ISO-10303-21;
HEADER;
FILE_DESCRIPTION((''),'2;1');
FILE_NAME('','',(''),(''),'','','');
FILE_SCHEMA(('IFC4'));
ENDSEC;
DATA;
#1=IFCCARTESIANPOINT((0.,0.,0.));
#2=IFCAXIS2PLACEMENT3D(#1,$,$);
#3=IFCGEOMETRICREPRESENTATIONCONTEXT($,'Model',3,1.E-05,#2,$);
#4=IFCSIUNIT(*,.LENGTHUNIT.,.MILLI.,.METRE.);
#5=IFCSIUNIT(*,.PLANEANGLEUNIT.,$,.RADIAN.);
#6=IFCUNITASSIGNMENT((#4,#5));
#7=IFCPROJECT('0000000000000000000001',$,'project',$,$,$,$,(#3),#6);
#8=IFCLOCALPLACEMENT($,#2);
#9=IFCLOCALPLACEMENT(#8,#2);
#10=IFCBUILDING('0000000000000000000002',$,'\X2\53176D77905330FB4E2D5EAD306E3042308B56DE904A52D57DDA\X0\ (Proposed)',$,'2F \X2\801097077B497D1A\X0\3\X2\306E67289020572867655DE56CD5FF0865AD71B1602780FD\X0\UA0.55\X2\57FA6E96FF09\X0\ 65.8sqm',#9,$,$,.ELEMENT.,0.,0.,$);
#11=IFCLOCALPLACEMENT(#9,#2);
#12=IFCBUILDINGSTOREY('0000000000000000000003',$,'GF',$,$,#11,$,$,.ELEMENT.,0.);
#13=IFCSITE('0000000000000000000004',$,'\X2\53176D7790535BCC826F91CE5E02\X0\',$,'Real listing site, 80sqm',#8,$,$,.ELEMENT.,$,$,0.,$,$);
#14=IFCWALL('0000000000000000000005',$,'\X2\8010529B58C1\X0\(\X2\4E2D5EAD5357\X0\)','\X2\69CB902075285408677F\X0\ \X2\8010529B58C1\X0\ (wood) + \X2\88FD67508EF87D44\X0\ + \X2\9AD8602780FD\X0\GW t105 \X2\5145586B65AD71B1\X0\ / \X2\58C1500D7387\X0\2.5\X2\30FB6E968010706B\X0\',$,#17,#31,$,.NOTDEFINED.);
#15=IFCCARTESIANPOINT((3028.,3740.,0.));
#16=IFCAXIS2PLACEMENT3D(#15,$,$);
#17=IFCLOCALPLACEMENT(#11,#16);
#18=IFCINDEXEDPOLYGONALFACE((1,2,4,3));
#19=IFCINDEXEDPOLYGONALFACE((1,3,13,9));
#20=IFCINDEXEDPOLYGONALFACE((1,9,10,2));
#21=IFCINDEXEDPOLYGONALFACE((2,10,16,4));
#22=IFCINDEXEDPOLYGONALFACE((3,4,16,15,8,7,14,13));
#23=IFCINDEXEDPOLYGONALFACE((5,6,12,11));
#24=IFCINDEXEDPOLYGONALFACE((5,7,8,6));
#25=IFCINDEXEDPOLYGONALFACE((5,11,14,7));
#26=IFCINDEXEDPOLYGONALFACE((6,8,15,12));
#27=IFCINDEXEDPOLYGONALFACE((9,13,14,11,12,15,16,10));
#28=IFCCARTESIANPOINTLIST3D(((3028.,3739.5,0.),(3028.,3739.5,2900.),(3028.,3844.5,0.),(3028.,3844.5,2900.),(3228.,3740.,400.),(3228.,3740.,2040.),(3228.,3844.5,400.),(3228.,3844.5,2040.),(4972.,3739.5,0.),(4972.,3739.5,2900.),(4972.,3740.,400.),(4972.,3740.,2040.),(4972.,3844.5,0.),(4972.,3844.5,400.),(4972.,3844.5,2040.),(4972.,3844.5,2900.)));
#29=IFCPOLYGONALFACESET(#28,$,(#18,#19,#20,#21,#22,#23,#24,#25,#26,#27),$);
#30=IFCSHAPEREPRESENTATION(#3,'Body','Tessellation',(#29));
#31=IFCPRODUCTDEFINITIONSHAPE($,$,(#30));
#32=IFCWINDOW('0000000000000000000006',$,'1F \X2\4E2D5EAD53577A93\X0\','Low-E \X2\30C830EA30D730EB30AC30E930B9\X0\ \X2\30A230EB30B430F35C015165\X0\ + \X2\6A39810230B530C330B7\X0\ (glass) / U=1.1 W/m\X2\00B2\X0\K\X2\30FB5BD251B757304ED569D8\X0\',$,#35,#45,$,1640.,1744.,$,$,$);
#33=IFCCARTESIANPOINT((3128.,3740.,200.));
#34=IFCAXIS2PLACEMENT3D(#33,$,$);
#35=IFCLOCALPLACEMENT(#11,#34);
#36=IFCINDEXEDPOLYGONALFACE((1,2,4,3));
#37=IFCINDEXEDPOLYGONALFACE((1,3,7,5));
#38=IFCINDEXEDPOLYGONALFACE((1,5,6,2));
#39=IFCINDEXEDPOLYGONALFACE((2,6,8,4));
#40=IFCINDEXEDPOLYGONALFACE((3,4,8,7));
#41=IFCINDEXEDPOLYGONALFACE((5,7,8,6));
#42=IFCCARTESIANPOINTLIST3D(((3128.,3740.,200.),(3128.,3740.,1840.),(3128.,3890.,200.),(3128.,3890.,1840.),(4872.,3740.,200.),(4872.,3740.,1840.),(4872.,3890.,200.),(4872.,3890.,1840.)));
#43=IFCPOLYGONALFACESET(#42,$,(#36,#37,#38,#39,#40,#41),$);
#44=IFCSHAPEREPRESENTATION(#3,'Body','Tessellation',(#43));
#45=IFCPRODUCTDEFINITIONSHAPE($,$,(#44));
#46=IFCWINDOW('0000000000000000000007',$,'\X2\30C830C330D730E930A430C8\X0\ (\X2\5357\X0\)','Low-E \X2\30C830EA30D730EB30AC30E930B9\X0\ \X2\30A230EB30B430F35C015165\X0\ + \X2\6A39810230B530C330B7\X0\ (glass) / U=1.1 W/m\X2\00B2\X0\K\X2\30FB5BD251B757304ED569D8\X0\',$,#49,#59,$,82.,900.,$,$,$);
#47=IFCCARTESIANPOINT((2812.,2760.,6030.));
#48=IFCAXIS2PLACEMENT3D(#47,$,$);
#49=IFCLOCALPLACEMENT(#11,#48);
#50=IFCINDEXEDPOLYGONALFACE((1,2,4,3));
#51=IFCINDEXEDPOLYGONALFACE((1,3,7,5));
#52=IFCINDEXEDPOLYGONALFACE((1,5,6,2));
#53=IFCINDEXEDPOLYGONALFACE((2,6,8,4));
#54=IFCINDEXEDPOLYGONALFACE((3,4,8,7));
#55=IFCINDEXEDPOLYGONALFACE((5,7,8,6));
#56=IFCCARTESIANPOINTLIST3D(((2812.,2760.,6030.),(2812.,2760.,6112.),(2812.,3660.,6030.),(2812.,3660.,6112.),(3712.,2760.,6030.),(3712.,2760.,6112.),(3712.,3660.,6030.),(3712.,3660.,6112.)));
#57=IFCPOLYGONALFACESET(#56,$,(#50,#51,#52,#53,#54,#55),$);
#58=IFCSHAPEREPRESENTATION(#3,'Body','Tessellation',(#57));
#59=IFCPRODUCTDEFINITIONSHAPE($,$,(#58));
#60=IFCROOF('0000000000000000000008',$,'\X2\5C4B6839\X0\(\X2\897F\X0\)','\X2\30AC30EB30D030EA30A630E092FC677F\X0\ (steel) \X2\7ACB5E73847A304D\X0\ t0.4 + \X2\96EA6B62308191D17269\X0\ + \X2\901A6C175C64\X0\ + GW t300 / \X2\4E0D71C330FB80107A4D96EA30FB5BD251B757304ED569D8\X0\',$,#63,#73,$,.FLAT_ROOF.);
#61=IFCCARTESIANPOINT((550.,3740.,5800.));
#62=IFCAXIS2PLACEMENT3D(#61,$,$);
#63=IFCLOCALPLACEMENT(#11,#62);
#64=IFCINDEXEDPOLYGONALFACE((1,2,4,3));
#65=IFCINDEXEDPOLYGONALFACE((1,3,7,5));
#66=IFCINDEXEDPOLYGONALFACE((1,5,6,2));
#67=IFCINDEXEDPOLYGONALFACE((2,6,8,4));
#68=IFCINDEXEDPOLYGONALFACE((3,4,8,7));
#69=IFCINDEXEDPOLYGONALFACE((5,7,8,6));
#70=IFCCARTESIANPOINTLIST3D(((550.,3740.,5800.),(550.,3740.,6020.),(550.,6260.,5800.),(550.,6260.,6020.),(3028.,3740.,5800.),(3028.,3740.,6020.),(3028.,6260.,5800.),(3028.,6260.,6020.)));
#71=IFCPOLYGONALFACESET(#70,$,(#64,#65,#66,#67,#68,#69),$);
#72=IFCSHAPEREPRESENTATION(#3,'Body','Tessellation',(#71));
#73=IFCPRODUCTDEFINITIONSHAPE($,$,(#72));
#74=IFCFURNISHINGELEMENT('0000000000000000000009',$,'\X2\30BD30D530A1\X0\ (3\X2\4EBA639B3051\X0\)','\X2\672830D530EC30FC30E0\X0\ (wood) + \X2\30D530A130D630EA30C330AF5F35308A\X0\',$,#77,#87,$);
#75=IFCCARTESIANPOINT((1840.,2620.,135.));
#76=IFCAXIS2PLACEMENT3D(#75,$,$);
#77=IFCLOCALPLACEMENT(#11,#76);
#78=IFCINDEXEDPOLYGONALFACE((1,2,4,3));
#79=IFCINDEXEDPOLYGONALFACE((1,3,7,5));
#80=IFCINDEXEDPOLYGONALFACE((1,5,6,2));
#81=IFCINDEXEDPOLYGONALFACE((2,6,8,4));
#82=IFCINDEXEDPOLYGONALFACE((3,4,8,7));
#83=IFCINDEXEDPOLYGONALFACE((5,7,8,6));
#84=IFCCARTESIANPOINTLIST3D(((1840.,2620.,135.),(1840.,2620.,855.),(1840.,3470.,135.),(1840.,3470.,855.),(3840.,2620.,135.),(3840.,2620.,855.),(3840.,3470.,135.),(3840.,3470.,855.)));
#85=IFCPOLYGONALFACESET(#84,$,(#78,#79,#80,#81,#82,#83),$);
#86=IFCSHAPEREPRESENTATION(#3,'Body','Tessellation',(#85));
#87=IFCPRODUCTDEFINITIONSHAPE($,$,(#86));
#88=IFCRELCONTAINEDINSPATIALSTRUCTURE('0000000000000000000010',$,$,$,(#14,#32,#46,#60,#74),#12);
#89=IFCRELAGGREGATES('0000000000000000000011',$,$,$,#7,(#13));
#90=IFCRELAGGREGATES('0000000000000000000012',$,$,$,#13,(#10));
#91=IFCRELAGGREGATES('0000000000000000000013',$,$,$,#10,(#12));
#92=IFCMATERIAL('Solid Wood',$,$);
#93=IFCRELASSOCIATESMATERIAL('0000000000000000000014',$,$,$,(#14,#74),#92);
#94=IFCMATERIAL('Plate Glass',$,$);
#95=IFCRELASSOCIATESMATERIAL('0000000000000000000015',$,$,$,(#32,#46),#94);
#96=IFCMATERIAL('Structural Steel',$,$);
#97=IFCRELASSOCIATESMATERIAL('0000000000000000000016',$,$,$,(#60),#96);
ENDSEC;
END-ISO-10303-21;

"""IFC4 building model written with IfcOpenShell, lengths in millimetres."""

from ifc_helpers import new_model, si_unit, frame, frame_2d, origin, place, context, project, spatial, rectangle, extrude, material, element, fill, save


model = new_model("IFC4")

# Units and contexts
model_context = context("Model", 3, precision=1e-05, world=origin())
ifc_project = project(units=[si_unit("LENGTHUNIT", "METRE", prefix="MILLI"), si_unit("PLANEANGLEUNIT", "RADIAN")], contexts=[model_context])

# Site, building, storey
site_placement = place(None, origin())
site = spatial("IfcSite", under=ifc_project, at=site_placement, Name="北海道富良野市", ObjectType="Real listing site, 80sqm", CompositionType="ELEMENT", RefElevation=0.0)
building_placement = place(site_placement, origin())
building = spatial("IfcBuilding", under=site, at=building_placement, Name="北海道・中庭のある回遊動線 (Proposed)", ObjectType="2F 耐震等級3の木造在来工法（断熱性能UA0.55基準） 65.8sqm", CompositionType="ELEMENT", ElevationOfRefHeight=0.0, ElevationOfTerrain=0.0)
storey_placement = place(building_placement, origin())
storey = spatial("IfcBuildingStorey", under=building, at=storey_placement, Name="GF", CompositionType="ELEMENT", Elevation=0.0)

# Shared definitions
ifc_material_1 = material(Name="Solid Wood")

# Wall, opening, window
wall_placement = place(storey_placement, frame((3028.0, 3740.0, 0.0)))
wall = element("IfcWall", 1, at=wall_placement, inside=storey, material=ifc_material_1, Name="耐力壁(中庭南)", Description="構造用合板 耐力壁 (wood) + 製材軸組 + 高性能GW t105 充填断熱 / 壁倍率2.5・準耐火", PredefinedType="NOTDEFINED", context=model_context, shape_type="SweptSolid", body=[
    extrude(rectangle(XDim=1944.0, YDim=105.0, at=frame_2d((972.0, 52.0))), frame((3028.0, 3740.0, 0.0)), (0.0, 0.0, 1.0), 2900.0),
])
opening_placement = place(storey_placement, frame((3128.0, 3740.0, 200.0)))
opening = element("IfcOpeningElement", 2, at=opening_placement, cuts=wall, PredefinedType="NOTDEFINED", context=model_context, shape_type="SweptSolid", body=[
    extrude(rectangle(XDim=1744.0, YDim=150.0, at=frame_2d((872.0, 75.0))), frame((3128.0, 3740.0, 200.0)), (0.0, 0.0, 1.0), 1640.0),
])
ifc_material_2 = material(Name="Plate Glass")
window_1_placement = place(storey_placement, frame((3128.0, 3740.0, 200.0)))
window_1 = element("IfcWindow", 3, at=window_1_placement, inside=storey, material=ifc_material_2, Name="1F 中庭南窓", Description="Low-E トリプルガラス アルゴン封入 + 樹脂サッシ (glass) / U=1.1 W/m²K・寒冷地仕様", OverallHeight=1640.0, OverallWidth=1744.0, context=model_context, shape_type="SweptSolid", body=[
    extrude(rectangle(XDim=1744.0, YDim=150.0, at=frame_2d((872.0, 75.0))), frame((3128.0, 3740.0, 200.0)), (0.0, 0.0, 1.0), 1640.0),
])
fill(opening, window_1)

# Window
window_2_placement = place(storey_placement, frame((2812.0, 2760.0, 6030.0)))
element("IfcWindow", 4, at=window_2_placement, inside=storey, material=ifc_material_2, Name="トップライト (南)", Description="Low-E トリプルガラス アルゴン封入 + 樹脂サッシ (glass) / U=1.1 W/m²K・寒冷地仕様", OverallHeight=82.0, OverallWidth=900.0, context=model_context, shape_type="SweptSolid", body=[
    extrude(rectangle(XDim=900.0, YDim=900.0, at=frame_2d((450.0, 450.0))), frame((2812.0, 2760.0, 6030.0)), (0.0, 0.0, 1.0), 82.0),
])

# Roof
ifc_material_3 = material(Name="Structural Steel")
for number, where, name in (
    (5, (550.0, 3740.0, 5800.0), "屋根(西)"),
):
    element("IfcRoof", number, at=place(storey_placement, frame(where)), inside=storey, material=ifc_material_3, Name=name, Description="ガルバリウム鋼板 (steel) 立平葺き t0.4 + 雪止め金物 + 通気層 + GW t300 / 不燃・耐積雪・寒冷地仕様", PredefinedType="FLAT_ROOF", context=model_context, shape_type="SweptSolid", body=[
        extrude(rectangle(XDim=2478.0, YDim=2520.0, at=frame_2d((1239.0, 1260.0))), frame((550.0, 3740.0, 5800.0)), (0.0, 0.0, 1.0), 220.0),
    ])

# Furnishing element
furnishing_placement = place(storey_placement, frame((1840.0, 2620.0, 135.0)))
element("IfcFurnishingElement", 6, at=furnishing_placement, inside=storey, material=ifc_material_1, Name="ソファ (3人掛け)", Description="木フレーム (wood) + ファブリック張り", context=model_context, shape_type="SweptSolid", body=[
    extrude(rectangle(XDim=2000.0, YDim=850.0, at=frame_2d((1000.0, 425.0))), frame((1840.0, 2620.0, 135.0)), (0.0, 0.0, 1.0), 720.0),
])

save(model, "model.ifc")
